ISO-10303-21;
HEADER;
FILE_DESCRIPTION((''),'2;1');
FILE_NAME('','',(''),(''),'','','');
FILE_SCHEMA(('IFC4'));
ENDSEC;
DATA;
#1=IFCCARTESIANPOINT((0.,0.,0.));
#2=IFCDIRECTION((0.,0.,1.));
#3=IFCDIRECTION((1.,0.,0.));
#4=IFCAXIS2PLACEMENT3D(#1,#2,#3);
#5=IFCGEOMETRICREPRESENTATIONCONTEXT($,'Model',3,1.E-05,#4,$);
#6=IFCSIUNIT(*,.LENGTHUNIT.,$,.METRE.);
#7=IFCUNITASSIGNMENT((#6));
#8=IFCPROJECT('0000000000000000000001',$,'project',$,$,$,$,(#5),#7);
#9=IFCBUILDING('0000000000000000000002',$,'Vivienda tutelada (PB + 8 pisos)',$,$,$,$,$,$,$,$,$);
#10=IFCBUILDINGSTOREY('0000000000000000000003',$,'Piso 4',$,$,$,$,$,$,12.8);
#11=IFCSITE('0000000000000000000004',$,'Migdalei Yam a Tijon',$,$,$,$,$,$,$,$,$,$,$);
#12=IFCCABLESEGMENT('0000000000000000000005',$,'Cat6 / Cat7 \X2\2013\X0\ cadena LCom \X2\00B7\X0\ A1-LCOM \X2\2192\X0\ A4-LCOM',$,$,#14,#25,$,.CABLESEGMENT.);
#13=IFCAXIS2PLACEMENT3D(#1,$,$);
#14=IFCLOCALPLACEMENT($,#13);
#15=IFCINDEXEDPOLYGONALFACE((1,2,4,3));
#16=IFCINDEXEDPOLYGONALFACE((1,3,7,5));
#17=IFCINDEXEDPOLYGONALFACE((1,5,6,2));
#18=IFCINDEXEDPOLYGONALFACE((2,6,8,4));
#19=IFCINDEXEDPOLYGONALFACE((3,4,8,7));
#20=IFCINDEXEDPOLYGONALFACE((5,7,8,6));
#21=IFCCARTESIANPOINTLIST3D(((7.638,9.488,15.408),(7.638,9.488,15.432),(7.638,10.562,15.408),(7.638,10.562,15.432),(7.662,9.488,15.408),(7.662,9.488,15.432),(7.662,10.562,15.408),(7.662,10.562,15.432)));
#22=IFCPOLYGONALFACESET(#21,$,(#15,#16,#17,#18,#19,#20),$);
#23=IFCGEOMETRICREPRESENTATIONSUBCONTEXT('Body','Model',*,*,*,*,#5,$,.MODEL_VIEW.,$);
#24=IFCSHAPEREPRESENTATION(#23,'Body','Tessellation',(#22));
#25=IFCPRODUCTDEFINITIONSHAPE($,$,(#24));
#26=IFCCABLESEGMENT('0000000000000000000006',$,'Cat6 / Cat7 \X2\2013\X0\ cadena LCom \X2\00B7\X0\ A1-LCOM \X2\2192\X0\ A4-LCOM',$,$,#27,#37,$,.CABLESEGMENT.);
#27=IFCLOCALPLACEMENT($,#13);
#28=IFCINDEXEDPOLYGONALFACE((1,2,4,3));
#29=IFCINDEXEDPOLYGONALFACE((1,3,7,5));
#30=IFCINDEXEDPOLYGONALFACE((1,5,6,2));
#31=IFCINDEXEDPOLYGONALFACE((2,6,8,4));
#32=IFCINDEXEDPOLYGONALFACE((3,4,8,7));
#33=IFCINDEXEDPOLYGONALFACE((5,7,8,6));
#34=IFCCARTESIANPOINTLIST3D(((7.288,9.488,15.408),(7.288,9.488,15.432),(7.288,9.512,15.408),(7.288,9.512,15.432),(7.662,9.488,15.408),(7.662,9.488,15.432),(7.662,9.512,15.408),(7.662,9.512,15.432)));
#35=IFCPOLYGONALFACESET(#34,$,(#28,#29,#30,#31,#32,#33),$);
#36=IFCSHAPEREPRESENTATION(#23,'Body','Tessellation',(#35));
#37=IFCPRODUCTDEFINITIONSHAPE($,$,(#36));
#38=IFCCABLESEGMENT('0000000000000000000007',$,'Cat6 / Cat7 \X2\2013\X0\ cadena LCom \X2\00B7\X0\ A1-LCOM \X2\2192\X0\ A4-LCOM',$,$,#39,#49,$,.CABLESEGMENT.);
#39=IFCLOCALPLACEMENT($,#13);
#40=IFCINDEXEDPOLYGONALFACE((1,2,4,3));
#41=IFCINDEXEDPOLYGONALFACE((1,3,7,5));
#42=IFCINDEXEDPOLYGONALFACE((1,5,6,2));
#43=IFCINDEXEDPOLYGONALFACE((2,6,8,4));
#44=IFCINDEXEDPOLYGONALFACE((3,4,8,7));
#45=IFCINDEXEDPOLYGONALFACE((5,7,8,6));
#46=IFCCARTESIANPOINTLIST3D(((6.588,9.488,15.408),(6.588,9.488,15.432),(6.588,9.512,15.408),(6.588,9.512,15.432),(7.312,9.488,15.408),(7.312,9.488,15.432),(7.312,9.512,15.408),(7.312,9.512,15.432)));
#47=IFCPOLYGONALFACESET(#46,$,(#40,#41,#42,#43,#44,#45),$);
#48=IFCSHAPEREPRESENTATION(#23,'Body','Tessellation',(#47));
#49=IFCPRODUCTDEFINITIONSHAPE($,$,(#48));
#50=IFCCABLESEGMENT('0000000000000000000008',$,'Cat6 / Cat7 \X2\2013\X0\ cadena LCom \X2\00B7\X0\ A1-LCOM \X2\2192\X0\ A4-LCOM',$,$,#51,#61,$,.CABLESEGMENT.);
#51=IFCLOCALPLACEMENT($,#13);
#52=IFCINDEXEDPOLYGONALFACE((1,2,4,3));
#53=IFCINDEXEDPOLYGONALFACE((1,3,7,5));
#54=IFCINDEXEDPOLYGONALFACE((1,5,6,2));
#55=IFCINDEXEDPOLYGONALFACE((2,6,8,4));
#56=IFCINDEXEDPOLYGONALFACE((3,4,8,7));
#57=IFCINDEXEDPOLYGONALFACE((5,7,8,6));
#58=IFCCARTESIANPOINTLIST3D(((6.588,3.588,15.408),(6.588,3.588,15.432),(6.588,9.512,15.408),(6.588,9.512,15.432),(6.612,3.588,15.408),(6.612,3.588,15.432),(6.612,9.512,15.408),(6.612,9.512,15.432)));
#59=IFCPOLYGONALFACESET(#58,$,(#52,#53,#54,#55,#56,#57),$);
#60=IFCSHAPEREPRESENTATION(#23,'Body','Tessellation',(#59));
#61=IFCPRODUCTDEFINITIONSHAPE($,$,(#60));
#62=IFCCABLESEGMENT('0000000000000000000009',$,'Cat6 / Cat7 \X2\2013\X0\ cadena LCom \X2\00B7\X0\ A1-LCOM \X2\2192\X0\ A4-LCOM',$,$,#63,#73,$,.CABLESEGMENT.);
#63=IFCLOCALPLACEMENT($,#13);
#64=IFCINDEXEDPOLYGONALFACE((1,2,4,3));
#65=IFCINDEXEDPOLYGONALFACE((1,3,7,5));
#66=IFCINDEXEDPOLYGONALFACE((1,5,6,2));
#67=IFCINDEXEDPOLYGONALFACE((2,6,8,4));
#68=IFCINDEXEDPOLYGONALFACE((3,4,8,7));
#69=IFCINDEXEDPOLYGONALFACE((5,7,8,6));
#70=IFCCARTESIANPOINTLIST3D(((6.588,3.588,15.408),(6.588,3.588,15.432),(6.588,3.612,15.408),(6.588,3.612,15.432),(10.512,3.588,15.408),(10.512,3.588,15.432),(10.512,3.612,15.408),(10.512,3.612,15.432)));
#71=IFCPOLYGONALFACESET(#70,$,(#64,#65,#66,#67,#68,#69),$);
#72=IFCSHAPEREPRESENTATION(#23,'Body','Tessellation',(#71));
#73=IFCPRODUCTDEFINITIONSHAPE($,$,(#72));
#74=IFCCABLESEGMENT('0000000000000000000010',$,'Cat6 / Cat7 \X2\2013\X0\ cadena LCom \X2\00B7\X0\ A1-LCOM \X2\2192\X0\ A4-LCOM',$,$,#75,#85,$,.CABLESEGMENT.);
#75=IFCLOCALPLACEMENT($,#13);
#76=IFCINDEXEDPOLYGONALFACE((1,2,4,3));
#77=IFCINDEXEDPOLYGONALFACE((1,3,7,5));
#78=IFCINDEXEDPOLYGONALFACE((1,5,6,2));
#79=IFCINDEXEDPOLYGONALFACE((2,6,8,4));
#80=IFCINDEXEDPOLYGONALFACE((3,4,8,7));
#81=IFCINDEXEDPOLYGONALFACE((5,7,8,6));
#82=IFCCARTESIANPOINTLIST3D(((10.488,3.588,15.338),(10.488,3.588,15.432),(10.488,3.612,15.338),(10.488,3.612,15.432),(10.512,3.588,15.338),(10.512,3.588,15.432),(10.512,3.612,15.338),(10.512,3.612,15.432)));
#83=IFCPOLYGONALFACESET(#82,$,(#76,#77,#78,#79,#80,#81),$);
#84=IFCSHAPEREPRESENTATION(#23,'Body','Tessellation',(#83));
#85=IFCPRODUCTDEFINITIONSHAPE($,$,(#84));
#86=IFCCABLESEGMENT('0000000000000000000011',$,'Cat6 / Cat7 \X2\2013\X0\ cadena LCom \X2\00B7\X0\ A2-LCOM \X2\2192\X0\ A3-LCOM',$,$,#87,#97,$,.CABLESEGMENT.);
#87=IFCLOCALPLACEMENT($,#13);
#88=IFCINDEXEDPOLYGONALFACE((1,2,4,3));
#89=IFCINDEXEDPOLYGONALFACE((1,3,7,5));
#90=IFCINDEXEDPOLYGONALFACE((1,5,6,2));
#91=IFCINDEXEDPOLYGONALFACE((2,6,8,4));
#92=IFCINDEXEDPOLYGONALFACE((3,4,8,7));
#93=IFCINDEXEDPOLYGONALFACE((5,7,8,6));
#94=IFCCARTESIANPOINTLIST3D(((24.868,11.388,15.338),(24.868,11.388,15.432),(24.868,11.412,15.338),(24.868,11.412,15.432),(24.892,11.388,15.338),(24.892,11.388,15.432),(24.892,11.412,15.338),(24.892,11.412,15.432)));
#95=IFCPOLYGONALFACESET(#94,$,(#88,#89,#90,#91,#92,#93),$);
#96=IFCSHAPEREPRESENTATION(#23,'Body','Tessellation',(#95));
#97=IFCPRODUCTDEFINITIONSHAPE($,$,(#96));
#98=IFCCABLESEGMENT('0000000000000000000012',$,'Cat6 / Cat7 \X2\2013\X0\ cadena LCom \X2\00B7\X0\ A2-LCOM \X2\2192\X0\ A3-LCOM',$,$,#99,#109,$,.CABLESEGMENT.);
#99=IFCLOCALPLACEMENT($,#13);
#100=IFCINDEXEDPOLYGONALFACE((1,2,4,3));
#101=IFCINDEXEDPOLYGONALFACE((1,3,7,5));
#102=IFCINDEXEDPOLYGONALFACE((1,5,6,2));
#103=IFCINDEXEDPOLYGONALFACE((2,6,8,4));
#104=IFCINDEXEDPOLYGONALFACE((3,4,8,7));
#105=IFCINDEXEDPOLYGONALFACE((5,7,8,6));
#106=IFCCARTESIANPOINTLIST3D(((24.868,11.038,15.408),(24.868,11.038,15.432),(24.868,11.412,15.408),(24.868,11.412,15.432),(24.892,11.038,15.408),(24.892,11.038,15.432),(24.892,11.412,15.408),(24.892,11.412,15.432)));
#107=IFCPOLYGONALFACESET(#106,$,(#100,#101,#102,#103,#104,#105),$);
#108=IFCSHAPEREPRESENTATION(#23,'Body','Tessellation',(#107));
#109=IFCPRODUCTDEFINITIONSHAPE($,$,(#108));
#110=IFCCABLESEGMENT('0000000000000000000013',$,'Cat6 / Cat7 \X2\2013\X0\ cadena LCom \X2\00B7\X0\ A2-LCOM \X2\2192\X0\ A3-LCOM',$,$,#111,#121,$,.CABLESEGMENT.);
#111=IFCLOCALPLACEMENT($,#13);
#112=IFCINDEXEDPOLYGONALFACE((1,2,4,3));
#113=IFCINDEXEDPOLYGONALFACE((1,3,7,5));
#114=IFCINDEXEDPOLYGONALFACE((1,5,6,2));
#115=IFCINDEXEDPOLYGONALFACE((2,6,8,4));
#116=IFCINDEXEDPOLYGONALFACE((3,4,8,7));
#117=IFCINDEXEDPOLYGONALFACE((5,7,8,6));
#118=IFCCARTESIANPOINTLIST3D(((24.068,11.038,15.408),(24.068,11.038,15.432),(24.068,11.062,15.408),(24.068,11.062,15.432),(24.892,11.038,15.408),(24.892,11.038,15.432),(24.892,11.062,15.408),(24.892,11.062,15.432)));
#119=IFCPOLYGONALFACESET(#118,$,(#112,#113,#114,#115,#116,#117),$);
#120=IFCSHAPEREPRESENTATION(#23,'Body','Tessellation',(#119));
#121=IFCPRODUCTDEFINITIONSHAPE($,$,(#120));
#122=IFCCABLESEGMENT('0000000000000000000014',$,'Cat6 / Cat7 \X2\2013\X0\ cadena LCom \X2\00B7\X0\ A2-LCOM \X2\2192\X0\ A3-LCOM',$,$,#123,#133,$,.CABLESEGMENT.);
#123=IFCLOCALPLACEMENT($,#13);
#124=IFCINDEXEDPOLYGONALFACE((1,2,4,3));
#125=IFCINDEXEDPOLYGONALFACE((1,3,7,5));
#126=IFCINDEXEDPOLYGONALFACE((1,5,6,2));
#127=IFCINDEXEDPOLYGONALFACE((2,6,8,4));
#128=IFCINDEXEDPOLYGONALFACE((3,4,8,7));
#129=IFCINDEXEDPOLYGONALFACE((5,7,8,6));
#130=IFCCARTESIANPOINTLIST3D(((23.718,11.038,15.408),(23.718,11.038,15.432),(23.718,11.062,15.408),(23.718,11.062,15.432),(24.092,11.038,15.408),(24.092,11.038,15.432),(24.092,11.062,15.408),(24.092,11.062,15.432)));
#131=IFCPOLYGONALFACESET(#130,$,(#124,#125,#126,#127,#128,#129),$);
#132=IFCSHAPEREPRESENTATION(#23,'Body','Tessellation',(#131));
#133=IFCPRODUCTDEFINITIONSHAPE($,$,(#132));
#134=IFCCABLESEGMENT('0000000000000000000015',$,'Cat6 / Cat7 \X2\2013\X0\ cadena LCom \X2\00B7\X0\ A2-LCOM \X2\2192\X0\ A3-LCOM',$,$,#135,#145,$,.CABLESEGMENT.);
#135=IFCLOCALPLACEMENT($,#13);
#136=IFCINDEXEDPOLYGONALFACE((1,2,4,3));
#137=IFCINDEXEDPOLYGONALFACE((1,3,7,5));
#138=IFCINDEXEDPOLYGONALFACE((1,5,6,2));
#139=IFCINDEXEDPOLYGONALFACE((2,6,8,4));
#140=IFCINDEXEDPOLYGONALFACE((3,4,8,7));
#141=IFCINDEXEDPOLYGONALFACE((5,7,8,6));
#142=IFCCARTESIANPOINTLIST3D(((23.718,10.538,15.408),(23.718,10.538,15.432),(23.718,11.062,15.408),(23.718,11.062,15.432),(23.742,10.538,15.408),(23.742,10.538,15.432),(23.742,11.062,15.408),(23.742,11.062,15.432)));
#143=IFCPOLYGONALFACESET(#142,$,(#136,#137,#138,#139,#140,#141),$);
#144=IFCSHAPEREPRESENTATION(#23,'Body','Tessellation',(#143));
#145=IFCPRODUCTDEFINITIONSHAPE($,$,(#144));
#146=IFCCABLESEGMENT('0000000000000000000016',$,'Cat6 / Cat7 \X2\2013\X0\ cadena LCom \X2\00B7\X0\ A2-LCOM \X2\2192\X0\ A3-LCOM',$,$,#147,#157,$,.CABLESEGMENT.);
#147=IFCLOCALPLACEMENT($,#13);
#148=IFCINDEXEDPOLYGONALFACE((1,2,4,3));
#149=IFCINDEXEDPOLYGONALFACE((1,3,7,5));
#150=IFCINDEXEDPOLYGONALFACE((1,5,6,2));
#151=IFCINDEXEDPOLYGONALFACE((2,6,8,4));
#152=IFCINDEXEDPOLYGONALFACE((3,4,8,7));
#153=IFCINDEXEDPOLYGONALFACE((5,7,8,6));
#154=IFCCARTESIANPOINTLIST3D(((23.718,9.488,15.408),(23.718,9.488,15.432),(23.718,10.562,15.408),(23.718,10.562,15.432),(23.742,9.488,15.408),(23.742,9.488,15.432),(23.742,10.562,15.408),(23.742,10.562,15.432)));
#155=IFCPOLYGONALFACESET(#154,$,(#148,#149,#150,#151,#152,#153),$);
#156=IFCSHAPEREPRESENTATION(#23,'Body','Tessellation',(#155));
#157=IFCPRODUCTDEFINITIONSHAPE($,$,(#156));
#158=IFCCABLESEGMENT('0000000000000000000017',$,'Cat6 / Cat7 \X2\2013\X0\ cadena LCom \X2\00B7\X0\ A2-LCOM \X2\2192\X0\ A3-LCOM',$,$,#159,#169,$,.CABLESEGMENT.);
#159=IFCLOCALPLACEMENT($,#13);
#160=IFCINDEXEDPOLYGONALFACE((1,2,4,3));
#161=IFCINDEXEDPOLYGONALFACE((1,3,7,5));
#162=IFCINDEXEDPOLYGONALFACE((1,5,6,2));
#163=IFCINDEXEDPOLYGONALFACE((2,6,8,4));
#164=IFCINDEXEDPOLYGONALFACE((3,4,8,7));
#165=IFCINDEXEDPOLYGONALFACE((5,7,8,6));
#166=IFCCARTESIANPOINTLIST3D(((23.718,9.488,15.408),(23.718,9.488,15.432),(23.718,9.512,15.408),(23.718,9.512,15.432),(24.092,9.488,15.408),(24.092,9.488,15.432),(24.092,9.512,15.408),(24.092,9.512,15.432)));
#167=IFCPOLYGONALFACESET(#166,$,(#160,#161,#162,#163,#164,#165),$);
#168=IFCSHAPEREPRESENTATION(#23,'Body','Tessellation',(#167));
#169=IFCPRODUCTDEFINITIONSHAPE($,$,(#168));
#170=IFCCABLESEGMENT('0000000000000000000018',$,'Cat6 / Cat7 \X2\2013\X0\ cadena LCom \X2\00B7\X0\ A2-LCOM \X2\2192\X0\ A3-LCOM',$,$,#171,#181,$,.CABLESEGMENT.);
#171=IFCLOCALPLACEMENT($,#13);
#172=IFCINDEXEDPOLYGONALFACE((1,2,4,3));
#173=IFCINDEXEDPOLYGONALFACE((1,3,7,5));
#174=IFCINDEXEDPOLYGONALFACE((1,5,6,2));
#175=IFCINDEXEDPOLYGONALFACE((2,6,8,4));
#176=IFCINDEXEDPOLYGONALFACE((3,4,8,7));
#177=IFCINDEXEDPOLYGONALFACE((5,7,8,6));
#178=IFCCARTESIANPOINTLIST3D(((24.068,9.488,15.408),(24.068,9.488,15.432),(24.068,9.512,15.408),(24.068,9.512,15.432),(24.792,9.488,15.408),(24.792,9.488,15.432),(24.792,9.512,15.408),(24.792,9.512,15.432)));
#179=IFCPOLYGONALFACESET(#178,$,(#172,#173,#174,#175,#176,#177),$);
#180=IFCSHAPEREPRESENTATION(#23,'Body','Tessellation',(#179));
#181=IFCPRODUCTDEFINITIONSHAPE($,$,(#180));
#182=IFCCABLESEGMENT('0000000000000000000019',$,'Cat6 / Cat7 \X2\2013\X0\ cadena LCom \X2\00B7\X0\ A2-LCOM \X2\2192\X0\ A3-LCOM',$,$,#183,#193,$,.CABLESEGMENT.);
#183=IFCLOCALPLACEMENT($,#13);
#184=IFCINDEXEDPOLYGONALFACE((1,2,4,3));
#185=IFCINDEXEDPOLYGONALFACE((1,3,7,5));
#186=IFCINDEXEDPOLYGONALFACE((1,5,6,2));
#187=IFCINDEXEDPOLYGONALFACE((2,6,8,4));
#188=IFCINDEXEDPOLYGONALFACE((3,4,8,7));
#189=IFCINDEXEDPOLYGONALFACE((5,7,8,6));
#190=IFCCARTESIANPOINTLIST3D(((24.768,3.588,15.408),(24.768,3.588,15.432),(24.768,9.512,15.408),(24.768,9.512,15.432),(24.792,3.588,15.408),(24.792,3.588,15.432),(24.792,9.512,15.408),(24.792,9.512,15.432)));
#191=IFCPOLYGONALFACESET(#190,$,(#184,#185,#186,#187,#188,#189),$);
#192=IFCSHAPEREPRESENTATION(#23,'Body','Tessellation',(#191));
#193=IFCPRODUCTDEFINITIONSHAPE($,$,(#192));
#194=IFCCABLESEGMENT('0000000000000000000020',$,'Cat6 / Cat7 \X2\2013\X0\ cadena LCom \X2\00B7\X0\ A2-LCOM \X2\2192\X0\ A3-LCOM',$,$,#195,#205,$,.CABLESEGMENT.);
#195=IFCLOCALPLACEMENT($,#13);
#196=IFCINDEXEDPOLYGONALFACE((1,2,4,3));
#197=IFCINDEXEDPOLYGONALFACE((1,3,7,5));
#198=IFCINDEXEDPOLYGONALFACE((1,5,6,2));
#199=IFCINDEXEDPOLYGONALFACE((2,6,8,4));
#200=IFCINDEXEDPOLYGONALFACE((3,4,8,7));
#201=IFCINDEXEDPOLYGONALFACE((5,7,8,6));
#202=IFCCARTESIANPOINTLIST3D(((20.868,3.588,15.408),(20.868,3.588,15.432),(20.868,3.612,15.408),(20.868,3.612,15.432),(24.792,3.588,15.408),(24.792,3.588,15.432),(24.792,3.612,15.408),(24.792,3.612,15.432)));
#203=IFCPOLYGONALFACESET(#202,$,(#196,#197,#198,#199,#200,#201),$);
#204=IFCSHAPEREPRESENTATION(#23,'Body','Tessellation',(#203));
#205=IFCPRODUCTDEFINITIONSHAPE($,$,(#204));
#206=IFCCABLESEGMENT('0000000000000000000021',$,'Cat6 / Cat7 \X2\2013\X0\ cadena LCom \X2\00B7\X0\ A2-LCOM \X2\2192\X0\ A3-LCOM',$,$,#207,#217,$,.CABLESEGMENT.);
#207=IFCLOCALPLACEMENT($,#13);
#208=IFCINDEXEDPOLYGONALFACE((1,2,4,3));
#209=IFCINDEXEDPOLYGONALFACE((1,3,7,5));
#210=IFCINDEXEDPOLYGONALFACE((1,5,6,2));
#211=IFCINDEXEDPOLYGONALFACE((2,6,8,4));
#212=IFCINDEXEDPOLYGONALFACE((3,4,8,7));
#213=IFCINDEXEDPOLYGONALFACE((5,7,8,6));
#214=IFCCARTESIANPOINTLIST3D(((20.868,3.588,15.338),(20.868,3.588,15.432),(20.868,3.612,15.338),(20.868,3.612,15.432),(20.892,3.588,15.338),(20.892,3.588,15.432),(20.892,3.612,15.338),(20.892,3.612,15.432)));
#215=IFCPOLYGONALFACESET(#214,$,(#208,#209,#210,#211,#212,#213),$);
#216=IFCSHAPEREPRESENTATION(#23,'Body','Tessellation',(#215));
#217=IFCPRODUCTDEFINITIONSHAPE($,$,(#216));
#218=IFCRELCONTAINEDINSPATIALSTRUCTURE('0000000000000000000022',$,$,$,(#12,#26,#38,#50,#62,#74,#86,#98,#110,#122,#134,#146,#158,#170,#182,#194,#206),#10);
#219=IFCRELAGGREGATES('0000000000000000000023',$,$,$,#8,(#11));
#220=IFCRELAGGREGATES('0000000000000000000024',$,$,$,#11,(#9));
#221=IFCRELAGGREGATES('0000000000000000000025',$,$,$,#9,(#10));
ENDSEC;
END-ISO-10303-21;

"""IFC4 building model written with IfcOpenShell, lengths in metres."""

from ifc_helpers import new_model, si_unit, frame, origin_with_axes, context, subcontext, project, spatial, line, indexed_curve, outline, extrude, element, save


model = new_model("IFC4")

# Units and contexts
model_context = context("Model", 3, precision=1e-05, world=origin_with_axes())
body_context = subcontext(model_context, "Body", "Model", "MODEL_VIEW")
ifc_project = project(units=[si_unit("LENGTHUNIT", "METRE")], contexts=[model_context])

# Site, building, storey
site = spatial("IfcSite", under=ifc_project, Name="Migdalei Yam a Tijon")
building = spatial("IfcBuilding", under=site, Name="Vivienda tutelada (PB + 8 pisos)")
storey = spatial("IfcBuildingStorey", under=building, Name="Piso 4", Elevation=12.8)

# Cable segments
element("IfcCableSegment", 1, inside=storey, Name="Cat6 / Cat7 – cadena LCom · A1-LCOM → A4-LCOM", PredefinedType="CABLESEGMENT", context=body_context, shape_type="SweptSolid", body=[
    extrude(outline(indexed_curve([(0.0, 0.0), (0.024, 0.0), (0.024, 1.074), (0.0, 1.074)], segments=[line(1, 2, 3, 4, 1)])), frame((7.638, 9.488, 15.408), z_axis=(0.0, 0.0, 1.0), x_axis=(1.0, 0.0, 0.0)), (0.0, 0.0, 1.0), 0.024),
])
element("IfcCableSegment", 2, inside=storey, Name="Cat6 / Cat7 – cadena LCom · A1-LCOM → A4-LCOM", PredefinedType="CABLESEGMENT", context=body_context, shape_type="SweptSolid", body=[
    extrude(outline(indexed_curve([(0.0, 0.0), (0.374, 0.0), (0.374, 0.024), (0.0, 0.024)], segments=[line(1, 2, 3, 4, 1)])), frame((7.288, 9.488, 15.408), z_axis=(0.0, 0.0, 1.0), x_axis=(1.0, 0.0, 0.0)), (0.0, 0.0, 1.0), 0.024),
])
element("IfcCableSegment", 3, inside=storey, Name="Cat6 / Cat7 – cadena LCom · A1-LCOM → A4-LCOM", PredefinedType="CABLESEGMENT", context=body_context, shape_type="SweptSolid", body=[
    extrude(outline(indexed_curve([(0.0, 0.0), (0.724, 0.0), (0.724, 0.024), (0.0, 0.024)], segments=[line(1, 2, 3, 4, 1)])), frame((6.588, 9.488, 15.408), z_axis=(0.0, 0.0, 1.0), x_axis=(1.0, 0.0, 0.0)), (0.0, 0.0, 1.0), 0.024),
])
element("IfcCableSegment", 4, inside=storey, Name="Cat6 / Cat7 – cadena LCom · A1-LCOM → A4-LCOM", PredefinedType="CABLESEGMENT", context=body_context, shape_type="SweptSolid", body=[
    extrude(outline(indexed_curve([(0.0, 0.0), (0.024, 0.0), (0.024, 5.924), (0.0, 5.924)], segments=[line(1, 2, 3, 4, 1)])), frame((6.588, 3.588, 15.408), z_axis=(0.0, 0.0, 1.0), x_axis=(1.0, 0.0, 0.0)), (0.0, 0.0, 1.0), 0.024),
])
element("IfcCableSegment", 5, inside=storey, Name="Cat6 / Cat7 – cadena LCom · A1-LCOM → A4-LCOM", PredefinedType="CABLESEGMENT", context=body_context, shape_type="SweptSolid", body=[
    extrude(outline(indexed_curve([(0.0, 0.0), (3.924, 0.0), (3.924, 0.024), (0.0, 0.024)], segments=[line(1, 2, 3, 4, 1)])), frame((6.588, 3.588, 15.408), z_axis=(0.0, 0.0, 1.0), x_axis=(1.0, 0.0, 0.0)), (0.0, 0.0, 1.0), 0.024),
])
element("IfcCableSegment", 6, inside=storey, Name="Cat6 / Cat7 – cadena LCom · A1-LCOM → A4-LCOM", PredefinedType="CABLESEGMENT", context=body_context, shape_type="SweptSolid", body=[
    extrude(outline(indexed_curve([(0.0, 0.0), (0.024, 0.0), (0.024, 0.024), (0.0, 0.024)], segments=[line(1, 2, 3, 4, 1)])), frame((10.488, 3.588, 15.338), z_axis=(0.0, 0.0, 1.0), x_axis=(1.0, 0.0, 0.0)), (0.0, 0.0, 1.0), 0.094),
])
element("IfcCableSegment", 7, inside=storey, Name="Cat6 / Cat7 – cadena LCom · A2-LCOM → A3-LCOM", PredefinedType="CABLESEGMENT", context=body_context, shape_type="SweptSolid", body=[
    extrude(outline(indexed_curve([(0.0, 0.0), (0.024, 0.0), (0.024, 0.024), (0.0, 0.024)], segments=[line(1, 2, 3, 4, 1)])), frame((24.868, 11.388, 15.338), z_axis=(0.0, 0.0, 1.0), x_axis=(1.0, 0.0, 0.0)), (0.0, 0.0, 1.0), 0.094),
])
element("IfcCableSegment", 8, inside=storey, Name="Cat6 / Cat7 – cadena LCom · A2-LCOM → A3-LCOM", PredefinedType="CABLESEGMENT", context=body_context, shape_type="SweptSolid", body=[
    extrude(outline(indexed_curve([(0.0, 0.0), (0.024, 0.0), (0.024, 0.374), (0.0, 0.374)], segments=[line(1, 2, 3, 4, 1)])), frame((24.868, 11.038, 15.408), z_axis=(0.0, 0.0, 1.0), x_axis=(1.0, 0.0, 0.0)), (0.0, 0.0, 1.0), 0.024),
])
element("IfcCableSegment", 9, inside=storey, Name="Cat6 / Cat7 – cadena LCom · A2-LCOM → A3-LCOM", PredefinedType="CABLESEGMENT", context=body_context, shape_type="SweptSolid", body=[
    extrude(outline(indexed_curve([(0.0, 0.0), (0.824, 0.0), (0.824, 0.024), (0.0, 0.024)], segments=[line(1, 2, 3, 4, 1)])), frame((24.068, 11.038, 15.408), z_axis=(0.0, 0.0, 1.0), x_axis=(1.0, 0.0, 0.0)), (0.0, 0.0, 1.0), 0.024),
])
element("IfcCableSegment", 10, inside=storey, Name="Cat6 / Cat7 – cadena LCom · A2-LCOM → A3-LCOM", PredefinedType="CABLESEGMENT", context=body_context, shape_type="SweptSolid", body=[
    extrude(outline(indexed_curve([(0.0, 0.0), (0.374, 0.0), (0.374, 0.024), (0.0, 0.024)], segments=[line(1, 2, 3, 4, 1)])), frame((23.718, 11.038, 15.408), z_axis=(0.0, 0.0, 1.0), x_axis=(1.0, 0.0, 0.0)), (0.0, 0.0, 1.0), 0.024),
])
element("IfcCableSegment", 11, inside=storey, Name="Cat6 / Cat7 – cadena LCom · A2-LCOM → A3-LCOM", PredefinedType="CABLESEGMENT", context=body_context, shape_type="SweptSolid", body=[
    extrude(outline(indexed_curve([(0.0, 0.0), (0.024, 0.0), (0.024, 0.524), (0.0, 0.524)], segments=[line(1, 2, 3, 4, 1)])), frame((23.718, 10.538, 15.408), z_axis=(0.0, 0.0, 1.0), x_axis=(1.0, 0.0, 0.0)), (0.0, 0.0, 1.0), 0.024),
])
element("IfcCableSegment", 12, inside=storey, Name="Cat6 / Cat7 – cadena LCom · A2-LCOM → A3-LCOM", PredefinedType="CABLESEGMENT", context=body_context, shape_type="SweptSolid", body=[
    extrude(outline(indexed_curve([(0.0, 0.0), (0.024, 0.0), (0.024, 1.074), (0.0, 1.074)], segments=[line(1, 2, 3, 4, 1)])), frame((23.718, 9.488, 15.408), z_axis=(0.0, 0.0, 1.0), x_axis=(1.0, 0.0, 0.0)), (0.0, 0.0, 1.0), 0.024),
])
element("IfcCableSegment", 13, inside=storey, Name="Cat6 / Cat7 – cadena LCom · A2-LCOM → A3-LCOM", PredefinedType="CABLESEGMENT", context=body_context, shape_type="SweptSolid", body=[
    extrude(outline(indexed_curve([(0.0, 0.0), (0.374, 0.0), (0.374, 0.024), (0.0, 0.024)], segments=[line(1, 2, 3, 4, 1)])), frame((23.718, 9.488, 15.408), z_axis=(0.0, 0.0, 1.0), x_axis=(1.0, 0.0, 0.0)), (0.0, 0.0, 1.0), 0.024),
])
element("IfcCableSegment", 14, inside=storey, Name="Cat6 / Cat7 – cadena LCom · A2-LCOM → A3-LCOM", PredefinedType="CABLESEGMENT", context=body_context, shape_type="SweptSolid", body=[
    extrude(outline(indexed_curve([(0.0, 0.0), (0.724, 0.0), (0.724, 0.024), (0.0, 0.024)], segments=[line(1, 2, 3, 4, 1)])), frame((24.068, 9.488, 15.408), z_axis=(0.0, 0.0, 1.0), x_axis=(1.0, 0.0, 0.0)), (0.0, 0.0, 1.0), 0.024),
])
element("IfcCableSegment", 15, inside=storey, Name="Cat6 / Cat7 – cadena LCom · A2-LCOM → A3-LCOM", PredefinedType="CABLESEGMENT", context=body_context, shape_type="SweptSolid", body=[
    extrude(outline(indexed_curve([(0.0, 0.0), (0.024, 0.0), (0.024, 5.924), (0.0, 5.924)], segments=[line(1, 2, 3, 4, 1)])), frame((24.768, 3.588, 15.408), z_axis=(0.0, 0.0, 1.0), x_axis=(1.0, 0.0, 0.0)), (0.0, 0.0, 1.0), 0.024),
])
element("IfcCableSegment", 16, inside=storey, Name="Cat6 / Cat7 – cadena LCom · A2-LCOM → A3-LCOM", PredefinedType="CABLESEGMENT", context=body_context, shape_type="SweptSolid", body=[
    extrude(outline(indexed_curve([(0.0, 0.0), (3.924, 0.0), (3.924, 0.024), (0.0, 0.024)], segments=[line(1, 2, 3, 4, 1)])), frame((20.868, 3.588, 15.408), z_axis=(0.0, 0.0, 1.0), x_axis=(1.0, 0.0, 0.0)), (0.0, 0.0, 1.0), 0.024),
])
element("IfcCableSegment", 17, inside=storey, Name="Cat6 / Cat7 – cadena LCom · A2-LCOM → A3-LCOM", PredefinedType="CABLESEGMENT", context=body_context, shape_type="SweptSolid", body=[
    extrude(outline(indexed_curve([(0.0, 0.0), (0.024, 0.0), (0.024, 0.024), (0.0, 0.024)], segments=[line(1, 2, 3, 4, 1)])), frame((20.868, 3.588, 15.338), z_axis=(0.0, 0.0, 1.0), x_axis=(1.0, 0.0, 0.0)), (0.0, 0.0, 1.0), 0.094),
])

save(model, "model.ifc")
